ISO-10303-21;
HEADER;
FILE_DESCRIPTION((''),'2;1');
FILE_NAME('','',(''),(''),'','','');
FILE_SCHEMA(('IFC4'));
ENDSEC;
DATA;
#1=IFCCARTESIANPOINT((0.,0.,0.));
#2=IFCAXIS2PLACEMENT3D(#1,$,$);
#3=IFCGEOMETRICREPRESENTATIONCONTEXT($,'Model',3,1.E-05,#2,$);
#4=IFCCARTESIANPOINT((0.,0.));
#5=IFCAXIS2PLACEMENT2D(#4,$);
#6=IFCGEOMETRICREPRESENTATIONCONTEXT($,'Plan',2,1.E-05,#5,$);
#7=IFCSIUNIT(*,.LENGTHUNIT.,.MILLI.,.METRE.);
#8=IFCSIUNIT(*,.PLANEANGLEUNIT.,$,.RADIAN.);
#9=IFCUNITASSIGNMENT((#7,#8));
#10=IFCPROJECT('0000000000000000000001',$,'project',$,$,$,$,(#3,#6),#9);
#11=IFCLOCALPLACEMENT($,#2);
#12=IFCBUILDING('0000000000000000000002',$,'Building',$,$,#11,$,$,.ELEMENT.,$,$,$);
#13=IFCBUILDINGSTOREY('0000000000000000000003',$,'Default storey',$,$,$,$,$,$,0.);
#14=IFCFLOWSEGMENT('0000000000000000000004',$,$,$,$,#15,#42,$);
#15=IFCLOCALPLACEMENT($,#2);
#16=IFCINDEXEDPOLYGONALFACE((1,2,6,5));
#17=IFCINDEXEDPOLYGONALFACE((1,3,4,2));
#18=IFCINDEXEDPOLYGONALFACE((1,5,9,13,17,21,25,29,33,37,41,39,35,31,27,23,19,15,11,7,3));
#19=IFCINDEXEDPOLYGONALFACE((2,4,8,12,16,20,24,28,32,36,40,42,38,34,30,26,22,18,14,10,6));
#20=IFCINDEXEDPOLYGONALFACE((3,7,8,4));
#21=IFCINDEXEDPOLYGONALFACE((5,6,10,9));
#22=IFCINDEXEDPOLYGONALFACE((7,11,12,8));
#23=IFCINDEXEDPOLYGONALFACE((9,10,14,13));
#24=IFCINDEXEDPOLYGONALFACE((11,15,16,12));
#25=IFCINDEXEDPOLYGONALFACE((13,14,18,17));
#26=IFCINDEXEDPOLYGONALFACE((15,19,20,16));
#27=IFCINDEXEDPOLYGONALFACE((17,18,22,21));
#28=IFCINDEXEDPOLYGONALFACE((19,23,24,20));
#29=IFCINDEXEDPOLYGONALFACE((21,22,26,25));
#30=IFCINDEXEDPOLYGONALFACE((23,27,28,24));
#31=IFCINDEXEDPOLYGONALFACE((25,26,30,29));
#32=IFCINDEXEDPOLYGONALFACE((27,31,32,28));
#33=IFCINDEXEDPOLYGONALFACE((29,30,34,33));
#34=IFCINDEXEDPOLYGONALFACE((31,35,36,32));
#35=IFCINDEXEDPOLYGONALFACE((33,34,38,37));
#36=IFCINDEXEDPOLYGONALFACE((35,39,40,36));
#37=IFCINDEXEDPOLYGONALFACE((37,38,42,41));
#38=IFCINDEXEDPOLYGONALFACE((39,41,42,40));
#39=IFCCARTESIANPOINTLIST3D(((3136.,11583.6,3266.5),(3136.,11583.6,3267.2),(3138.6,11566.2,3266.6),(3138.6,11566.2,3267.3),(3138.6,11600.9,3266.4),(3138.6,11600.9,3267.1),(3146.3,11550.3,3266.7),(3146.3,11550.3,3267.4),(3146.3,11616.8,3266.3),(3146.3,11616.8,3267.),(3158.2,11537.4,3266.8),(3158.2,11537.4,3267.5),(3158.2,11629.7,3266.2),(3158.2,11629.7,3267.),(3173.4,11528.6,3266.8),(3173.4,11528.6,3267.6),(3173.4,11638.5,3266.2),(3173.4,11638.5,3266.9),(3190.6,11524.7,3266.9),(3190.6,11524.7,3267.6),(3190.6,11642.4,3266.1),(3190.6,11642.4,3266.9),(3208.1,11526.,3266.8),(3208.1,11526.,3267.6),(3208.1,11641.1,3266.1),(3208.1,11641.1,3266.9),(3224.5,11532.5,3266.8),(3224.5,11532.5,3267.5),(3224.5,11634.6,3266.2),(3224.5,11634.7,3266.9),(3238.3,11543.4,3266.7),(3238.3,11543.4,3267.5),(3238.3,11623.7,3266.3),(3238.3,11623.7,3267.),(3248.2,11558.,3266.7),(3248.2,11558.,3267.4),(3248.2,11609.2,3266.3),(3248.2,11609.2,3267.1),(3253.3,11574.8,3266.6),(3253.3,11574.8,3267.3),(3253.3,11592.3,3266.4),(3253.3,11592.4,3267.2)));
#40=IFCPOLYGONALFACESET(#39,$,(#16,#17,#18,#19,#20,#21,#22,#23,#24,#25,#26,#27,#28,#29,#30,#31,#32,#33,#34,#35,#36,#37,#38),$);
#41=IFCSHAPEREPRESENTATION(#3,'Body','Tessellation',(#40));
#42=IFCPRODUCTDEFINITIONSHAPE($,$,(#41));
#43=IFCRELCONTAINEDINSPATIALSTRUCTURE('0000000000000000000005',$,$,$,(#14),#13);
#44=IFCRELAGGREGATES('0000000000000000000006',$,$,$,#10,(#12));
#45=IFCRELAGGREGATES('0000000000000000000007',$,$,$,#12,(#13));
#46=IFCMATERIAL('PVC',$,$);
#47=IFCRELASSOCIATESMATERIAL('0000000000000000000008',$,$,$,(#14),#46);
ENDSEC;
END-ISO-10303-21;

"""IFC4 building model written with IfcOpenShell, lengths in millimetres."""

from ifc_helpers import new_model, si_unit, frame, origin, origin_2d, place, context, project, spatial, circle, extrude, material, element, save


model = new_model("IFC4")

# Units and contexts
model_context = context("Model", 3, precision=1e-05, world=origin())
plan_context = context("Plan", 2, precision=1e-05, world=origin_2d())
ifc_project = project(units=[si_unit("LENGTHUNIT", "METRE", prefix="MILLI"), si_unit("PLANEANGLEUNIT", "RADIAN")], contexts=[model_context, plan_context])

# Building, storey
placement = place(None, origin())
building = spatial("IfcBuilding", under=ifc_project, at=placement, Name="Building", CompositionType="ELEMENT")
storey = spatial("IfcBuildingStorey", under=building, Name="Default storey", Elevation=0.0)

# Flow segment
ifc_material_1 = material(Name="PVC")
element("IfcFlowSegment", 1, at=placement, inside=storey, material=ifc_material_1, context=model_context, shape_type="SweptSolid", body=[
    extrude(circle(Radius=59.0, at=origin_2d()), frame((3195.0, 11583.6, 3267.2), z_axis=(0.0, -0.004455, -0.735017), x_axis=(-4.454647, 0.0, 0.0)), (0.0, 0.0, 1.0), 0.7),
])

save(model, "model.ifc")
